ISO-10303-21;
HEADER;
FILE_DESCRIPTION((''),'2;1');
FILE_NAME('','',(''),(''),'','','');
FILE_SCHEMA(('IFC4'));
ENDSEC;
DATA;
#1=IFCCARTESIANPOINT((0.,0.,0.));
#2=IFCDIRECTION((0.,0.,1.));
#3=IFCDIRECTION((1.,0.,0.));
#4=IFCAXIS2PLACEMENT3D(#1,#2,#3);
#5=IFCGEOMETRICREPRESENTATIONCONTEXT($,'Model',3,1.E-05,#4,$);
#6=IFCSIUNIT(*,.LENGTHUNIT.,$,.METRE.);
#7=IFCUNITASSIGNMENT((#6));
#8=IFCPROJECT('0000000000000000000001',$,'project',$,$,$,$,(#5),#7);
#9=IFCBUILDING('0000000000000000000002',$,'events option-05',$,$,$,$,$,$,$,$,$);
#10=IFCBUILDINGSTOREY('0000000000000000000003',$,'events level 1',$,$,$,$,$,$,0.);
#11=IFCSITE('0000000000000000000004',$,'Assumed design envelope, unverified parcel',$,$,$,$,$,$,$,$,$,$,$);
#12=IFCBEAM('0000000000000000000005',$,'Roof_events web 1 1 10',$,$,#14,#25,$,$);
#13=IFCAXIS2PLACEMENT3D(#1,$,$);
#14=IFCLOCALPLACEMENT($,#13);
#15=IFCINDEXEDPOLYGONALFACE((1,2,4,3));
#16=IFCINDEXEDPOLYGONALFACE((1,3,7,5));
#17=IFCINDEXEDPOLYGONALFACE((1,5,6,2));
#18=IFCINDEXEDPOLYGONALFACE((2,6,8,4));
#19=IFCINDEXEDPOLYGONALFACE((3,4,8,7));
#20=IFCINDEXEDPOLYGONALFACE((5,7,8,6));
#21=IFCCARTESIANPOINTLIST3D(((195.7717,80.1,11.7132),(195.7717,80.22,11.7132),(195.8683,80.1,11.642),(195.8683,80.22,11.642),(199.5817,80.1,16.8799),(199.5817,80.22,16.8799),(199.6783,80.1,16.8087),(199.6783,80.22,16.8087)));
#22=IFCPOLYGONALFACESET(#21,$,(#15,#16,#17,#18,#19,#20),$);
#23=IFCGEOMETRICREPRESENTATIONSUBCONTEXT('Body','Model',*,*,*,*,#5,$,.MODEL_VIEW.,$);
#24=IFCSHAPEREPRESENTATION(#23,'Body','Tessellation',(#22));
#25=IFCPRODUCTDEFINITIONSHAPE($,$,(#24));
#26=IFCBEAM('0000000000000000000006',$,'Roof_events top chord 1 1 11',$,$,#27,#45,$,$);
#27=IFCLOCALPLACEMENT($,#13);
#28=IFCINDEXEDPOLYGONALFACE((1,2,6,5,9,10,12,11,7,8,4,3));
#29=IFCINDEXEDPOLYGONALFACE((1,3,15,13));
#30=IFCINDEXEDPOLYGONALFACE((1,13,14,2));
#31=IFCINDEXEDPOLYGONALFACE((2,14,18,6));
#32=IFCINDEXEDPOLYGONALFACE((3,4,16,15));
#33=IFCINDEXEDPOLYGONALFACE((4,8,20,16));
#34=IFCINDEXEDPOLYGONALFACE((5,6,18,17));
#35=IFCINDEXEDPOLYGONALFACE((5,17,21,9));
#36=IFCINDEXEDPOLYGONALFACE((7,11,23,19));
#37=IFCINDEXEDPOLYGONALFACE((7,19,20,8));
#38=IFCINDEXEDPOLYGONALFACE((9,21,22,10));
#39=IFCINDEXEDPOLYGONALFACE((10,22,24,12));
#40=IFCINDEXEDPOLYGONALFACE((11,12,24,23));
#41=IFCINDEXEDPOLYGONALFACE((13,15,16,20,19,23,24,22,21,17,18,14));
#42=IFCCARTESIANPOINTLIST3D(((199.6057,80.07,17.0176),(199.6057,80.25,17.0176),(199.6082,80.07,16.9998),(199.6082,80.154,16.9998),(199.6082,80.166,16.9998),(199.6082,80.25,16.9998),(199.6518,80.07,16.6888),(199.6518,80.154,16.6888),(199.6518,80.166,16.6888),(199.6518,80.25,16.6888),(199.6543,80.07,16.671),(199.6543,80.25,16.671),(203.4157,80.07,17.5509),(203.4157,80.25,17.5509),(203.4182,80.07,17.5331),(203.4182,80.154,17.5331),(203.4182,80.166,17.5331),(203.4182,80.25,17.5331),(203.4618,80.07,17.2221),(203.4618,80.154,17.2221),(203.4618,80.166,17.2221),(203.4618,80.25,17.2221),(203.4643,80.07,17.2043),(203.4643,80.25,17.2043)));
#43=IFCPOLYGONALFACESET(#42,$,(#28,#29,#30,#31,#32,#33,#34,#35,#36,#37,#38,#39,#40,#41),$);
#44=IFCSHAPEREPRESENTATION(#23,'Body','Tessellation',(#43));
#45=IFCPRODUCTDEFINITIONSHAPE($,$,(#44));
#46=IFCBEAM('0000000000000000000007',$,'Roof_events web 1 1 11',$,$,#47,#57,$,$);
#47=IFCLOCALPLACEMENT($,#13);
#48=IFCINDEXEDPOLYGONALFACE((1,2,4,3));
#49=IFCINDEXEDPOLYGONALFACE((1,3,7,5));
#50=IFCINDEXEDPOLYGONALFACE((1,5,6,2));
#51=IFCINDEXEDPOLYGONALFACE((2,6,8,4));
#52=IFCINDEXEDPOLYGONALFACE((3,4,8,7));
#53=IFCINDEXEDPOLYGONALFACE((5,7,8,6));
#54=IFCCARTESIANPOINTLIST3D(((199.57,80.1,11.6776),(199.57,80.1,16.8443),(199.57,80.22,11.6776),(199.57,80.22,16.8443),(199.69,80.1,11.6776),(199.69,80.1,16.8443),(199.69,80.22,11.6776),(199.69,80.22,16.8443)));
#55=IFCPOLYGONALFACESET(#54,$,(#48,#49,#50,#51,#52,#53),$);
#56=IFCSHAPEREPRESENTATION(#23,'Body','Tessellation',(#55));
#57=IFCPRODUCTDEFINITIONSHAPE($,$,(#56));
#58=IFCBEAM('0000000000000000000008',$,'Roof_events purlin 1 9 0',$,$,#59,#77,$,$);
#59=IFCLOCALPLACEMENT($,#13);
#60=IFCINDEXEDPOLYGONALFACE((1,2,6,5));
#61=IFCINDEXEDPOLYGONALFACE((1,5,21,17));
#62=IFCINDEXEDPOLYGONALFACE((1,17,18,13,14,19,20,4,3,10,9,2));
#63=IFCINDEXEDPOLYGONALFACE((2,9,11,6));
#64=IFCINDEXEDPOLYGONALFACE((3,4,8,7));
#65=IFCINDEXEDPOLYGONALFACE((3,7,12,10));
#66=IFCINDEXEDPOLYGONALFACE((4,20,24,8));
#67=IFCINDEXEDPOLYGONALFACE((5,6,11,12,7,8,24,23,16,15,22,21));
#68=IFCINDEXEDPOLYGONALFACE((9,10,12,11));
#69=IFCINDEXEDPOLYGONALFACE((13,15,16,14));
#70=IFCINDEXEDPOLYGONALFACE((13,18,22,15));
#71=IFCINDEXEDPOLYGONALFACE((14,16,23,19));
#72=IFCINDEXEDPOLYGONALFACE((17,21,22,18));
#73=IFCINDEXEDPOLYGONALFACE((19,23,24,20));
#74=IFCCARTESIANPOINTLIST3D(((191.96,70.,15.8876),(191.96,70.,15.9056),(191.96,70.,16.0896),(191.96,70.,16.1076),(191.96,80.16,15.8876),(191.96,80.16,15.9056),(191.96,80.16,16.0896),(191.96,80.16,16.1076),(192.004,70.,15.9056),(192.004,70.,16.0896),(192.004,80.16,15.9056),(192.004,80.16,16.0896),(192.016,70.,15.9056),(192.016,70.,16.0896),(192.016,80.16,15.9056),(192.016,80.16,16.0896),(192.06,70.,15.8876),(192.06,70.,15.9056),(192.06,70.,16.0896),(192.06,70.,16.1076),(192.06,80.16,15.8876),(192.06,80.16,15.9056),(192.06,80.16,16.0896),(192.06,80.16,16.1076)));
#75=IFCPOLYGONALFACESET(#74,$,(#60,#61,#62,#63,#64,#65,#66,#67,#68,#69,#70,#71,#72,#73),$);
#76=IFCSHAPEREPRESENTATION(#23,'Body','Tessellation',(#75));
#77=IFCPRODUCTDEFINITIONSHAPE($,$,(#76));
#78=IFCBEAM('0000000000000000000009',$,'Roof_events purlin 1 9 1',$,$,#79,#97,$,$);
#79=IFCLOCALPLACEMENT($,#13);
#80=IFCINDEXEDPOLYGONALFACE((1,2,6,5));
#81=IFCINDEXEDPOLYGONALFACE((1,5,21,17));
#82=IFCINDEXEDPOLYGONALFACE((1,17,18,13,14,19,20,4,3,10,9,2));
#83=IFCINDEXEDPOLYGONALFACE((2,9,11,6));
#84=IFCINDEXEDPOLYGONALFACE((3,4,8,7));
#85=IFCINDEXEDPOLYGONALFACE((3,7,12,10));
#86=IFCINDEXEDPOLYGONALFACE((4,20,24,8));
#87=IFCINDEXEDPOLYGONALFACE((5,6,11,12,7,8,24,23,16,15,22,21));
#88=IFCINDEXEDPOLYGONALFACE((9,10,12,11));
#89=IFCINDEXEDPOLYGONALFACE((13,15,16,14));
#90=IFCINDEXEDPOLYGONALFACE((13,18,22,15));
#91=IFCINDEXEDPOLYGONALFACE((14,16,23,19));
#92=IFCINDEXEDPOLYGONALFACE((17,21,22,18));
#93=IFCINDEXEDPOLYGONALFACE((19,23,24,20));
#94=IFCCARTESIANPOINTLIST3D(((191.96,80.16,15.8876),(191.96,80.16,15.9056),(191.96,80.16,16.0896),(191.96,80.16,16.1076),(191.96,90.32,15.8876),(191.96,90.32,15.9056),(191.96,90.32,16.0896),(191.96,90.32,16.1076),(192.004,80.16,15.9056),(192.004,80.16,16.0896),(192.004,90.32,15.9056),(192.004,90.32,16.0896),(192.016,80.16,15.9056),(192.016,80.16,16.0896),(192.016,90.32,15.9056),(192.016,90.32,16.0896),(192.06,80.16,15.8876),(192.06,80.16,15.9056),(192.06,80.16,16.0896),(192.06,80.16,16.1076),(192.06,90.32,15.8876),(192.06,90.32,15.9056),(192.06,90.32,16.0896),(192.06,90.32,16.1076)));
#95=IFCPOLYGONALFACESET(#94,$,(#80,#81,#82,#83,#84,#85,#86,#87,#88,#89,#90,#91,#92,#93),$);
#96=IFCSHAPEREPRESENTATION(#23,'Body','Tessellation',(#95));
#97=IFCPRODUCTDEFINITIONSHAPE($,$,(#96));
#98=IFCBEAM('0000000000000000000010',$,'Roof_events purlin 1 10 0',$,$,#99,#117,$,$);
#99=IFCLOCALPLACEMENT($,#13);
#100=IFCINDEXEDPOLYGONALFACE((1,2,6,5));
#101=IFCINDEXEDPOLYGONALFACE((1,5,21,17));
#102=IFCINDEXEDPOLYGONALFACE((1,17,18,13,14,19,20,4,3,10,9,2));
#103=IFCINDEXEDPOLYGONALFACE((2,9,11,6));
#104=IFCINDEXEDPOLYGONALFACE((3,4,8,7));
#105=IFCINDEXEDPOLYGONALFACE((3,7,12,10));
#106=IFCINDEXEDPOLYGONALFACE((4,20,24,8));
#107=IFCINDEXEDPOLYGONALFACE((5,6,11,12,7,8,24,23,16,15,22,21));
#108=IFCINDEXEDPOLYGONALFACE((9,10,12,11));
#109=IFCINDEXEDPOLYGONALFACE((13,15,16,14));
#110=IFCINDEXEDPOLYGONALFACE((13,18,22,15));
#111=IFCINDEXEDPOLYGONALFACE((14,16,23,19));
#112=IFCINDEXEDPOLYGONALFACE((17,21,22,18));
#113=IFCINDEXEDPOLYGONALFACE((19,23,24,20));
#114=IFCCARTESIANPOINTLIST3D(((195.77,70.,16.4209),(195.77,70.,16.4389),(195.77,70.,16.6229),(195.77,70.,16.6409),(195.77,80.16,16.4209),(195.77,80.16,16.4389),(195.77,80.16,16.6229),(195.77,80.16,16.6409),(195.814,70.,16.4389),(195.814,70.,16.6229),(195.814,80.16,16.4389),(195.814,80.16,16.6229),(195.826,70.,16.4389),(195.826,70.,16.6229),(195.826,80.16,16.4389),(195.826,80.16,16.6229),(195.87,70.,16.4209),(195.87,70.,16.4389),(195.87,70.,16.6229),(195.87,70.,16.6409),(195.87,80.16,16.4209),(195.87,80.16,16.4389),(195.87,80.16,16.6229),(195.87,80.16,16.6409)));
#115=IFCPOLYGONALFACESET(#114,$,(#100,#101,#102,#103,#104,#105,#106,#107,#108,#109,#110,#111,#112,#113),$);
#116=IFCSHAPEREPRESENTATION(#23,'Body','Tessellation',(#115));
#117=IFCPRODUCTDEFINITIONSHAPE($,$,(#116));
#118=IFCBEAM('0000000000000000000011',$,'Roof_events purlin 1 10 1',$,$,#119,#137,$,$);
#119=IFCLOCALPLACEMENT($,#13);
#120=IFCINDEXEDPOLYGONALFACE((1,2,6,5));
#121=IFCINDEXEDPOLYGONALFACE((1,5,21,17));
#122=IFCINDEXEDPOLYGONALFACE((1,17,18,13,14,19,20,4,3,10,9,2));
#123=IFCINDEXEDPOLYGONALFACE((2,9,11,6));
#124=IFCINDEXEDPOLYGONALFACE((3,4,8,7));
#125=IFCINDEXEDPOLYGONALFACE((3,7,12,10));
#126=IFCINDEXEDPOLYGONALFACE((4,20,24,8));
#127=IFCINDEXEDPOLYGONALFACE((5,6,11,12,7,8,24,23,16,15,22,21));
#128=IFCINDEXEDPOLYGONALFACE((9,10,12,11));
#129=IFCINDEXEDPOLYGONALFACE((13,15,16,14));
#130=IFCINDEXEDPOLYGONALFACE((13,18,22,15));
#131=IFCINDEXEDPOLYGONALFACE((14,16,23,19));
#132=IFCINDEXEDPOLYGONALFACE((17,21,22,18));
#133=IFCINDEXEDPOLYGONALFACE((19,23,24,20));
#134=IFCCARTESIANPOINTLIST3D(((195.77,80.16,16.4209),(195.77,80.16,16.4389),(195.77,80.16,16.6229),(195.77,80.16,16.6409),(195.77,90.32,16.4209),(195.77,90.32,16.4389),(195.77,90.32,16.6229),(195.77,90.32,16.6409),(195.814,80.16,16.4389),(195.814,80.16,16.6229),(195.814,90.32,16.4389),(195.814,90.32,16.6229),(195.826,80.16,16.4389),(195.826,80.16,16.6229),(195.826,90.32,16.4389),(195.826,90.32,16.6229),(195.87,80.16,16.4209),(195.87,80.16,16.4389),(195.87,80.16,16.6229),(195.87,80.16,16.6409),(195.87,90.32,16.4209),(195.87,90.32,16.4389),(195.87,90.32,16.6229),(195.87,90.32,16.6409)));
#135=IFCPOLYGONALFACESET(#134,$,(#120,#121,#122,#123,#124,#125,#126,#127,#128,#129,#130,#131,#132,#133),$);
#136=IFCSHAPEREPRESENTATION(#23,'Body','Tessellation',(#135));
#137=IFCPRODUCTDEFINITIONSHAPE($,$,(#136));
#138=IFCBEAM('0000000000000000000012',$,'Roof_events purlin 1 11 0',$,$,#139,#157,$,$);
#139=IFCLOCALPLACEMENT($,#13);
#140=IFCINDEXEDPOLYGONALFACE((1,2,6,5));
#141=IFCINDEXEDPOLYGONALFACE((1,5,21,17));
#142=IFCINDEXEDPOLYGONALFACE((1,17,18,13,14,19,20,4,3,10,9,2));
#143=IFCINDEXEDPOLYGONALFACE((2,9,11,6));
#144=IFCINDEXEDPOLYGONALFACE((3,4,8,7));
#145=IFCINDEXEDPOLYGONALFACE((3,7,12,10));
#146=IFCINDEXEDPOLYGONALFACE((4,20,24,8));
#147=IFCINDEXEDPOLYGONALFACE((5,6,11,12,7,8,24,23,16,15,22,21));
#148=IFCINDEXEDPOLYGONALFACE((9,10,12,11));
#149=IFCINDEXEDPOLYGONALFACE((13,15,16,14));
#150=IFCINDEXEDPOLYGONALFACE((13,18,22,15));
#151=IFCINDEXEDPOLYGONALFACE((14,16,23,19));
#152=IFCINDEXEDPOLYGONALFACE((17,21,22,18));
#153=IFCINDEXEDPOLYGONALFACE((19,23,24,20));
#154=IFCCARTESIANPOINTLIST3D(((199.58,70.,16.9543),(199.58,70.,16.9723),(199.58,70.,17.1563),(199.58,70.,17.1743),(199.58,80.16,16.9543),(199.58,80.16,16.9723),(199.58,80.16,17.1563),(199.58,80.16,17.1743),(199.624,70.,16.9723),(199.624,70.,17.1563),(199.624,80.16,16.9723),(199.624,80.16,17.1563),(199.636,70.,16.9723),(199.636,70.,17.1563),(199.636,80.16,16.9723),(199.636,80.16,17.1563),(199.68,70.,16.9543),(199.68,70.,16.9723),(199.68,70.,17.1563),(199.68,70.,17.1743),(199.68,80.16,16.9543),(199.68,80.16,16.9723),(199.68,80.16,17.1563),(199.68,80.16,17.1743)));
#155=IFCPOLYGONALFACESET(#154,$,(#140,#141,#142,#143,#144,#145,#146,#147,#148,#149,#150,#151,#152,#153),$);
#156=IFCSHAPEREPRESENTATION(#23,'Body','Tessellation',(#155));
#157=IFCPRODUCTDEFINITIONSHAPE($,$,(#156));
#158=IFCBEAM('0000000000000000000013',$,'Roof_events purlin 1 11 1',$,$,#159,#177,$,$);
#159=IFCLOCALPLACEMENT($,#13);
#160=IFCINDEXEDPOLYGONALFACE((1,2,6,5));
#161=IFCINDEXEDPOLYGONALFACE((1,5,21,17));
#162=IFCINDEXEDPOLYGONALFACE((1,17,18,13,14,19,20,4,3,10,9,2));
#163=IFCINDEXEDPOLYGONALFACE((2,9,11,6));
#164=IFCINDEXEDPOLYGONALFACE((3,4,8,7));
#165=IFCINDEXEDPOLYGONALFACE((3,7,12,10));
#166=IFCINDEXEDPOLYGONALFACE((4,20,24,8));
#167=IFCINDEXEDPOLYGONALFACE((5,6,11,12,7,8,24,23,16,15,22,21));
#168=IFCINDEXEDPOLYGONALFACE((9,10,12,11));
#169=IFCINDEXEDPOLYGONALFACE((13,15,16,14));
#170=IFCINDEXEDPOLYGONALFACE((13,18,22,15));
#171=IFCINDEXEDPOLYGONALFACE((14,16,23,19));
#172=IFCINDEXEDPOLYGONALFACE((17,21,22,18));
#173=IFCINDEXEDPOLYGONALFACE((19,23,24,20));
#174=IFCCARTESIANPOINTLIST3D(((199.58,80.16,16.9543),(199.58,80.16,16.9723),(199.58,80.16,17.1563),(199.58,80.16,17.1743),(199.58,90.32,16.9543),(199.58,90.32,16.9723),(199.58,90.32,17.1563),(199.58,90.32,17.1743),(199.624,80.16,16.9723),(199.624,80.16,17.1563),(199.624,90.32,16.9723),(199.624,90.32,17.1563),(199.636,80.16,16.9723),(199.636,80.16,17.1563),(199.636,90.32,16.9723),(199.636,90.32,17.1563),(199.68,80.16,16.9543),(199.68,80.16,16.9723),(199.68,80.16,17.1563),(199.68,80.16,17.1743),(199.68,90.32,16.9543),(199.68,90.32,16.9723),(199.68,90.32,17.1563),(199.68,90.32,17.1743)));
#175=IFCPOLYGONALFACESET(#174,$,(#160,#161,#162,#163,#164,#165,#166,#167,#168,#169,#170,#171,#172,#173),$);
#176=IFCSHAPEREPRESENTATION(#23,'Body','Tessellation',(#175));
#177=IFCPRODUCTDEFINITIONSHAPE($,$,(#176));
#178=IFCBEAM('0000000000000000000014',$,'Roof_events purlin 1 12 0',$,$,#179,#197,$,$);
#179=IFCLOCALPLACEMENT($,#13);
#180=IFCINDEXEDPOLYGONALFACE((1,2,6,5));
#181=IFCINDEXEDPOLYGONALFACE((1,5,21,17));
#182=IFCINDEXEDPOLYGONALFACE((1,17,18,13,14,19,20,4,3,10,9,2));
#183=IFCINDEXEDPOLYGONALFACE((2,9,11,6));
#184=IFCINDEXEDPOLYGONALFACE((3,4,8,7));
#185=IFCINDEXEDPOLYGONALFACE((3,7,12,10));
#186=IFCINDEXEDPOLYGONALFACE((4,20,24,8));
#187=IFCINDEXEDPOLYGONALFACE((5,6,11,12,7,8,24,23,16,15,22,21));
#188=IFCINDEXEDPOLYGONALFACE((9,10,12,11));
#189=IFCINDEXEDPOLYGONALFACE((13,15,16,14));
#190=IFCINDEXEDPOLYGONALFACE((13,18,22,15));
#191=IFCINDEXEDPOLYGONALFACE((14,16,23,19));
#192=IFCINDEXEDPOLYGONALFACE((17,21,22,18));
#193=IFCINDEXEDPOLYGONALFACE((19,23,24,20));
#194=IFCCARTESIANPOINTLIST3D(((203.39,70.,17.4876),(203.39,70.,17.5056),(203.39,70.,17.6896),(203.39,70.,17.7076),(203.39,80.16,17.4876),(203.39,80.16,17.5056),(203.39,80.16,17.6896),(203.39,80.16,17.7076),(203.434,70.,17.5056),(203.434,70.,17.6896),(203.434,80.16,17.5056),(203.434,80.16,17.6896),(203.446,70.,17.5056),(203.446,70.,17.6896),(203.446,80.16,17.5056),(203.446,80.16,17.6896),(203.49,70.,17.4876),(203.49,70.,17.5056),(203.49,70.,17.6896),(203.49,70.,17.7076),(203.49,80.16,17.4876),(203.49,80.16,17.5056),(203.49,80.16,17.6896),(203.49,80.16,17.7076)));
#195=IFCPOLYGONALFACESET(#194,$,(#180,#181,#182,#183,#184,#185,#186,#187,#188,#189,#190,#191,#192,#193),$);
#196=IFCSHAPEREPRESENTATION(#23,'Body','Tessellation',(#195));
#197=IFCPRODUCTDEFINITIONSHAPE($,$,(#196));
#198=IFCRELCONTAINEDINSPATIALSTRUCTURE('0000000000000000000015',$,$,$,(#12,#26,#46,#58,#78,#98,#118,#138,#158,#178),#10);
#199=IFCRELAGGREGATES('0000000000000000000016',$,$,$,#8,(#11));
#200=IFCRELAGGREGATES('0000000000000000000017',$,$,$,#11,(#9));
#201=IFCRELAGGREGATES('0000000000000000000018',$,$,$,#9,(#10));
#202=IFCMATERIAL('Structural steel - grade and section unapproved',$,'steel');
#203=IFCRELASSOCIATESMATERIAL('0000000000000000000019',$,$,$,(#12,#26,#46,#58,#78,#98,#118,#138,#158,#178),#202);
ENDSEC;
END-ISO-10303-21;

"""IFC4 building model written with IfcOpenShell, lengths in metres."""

from ifc_helpers import new_model, si_unit, frame, origin_with_axes, place, context, subcontext, project, spatial, rectangle, i_section, extrude, material, element, save


model = new_model("IFC4")

# Units and contexts
model_context = context("Model", 3, precision=1e-05, world=origin_with_axes())
body_context = subcontext(model_context, "Body", "Model", "MODEL_VIEW")
ifc_project = project(units=[si_unit("LENGTHUNIT", "METRE")], contexts=[model_context])

# Site, building, storey
site = spatial("IfcSite", under=ifc_project, Name="Assumed design envelope, unverified parcel")
building = spatial("IfcBuilding", under=site, Name="events option-05")
storey = spatial("IfcBuildingStorey", under=building, Name="events level 1", Elevation=0.0)

# Shared definitions
ifc_material_1 = material(Name="Structural steel - grade and section unapproved", Category="steel")

# Beams
beam_1_placement = place(None, frame((195.82, 80.16, 11.6776), z_axis=(0.5935, 0.0, 0.804834), x_axis=(0.0, 1.0, 0.0)))
element("IfcBeam", 1, at=beam_1_placement, inside=storey, material=ifc_material_1, Name="Roof_events web 1 1 10", context=body_context, shape_type="SweptSolid", body=[
    extrude(rectangle(XDim=0.12, YDim=0.12), origin_with_axes(), (0.0, 0.0, 1.0), 6.4195),
])
beam_2_placement = place(None, frame((199.63, 80.16, 16.8443), z_axis=(0.990344, 0.0, 0.138631), x_axis=(0.0, 1.0, 0.0)))
element("IfcBeam", 2, at=beam_2_placement, inside=storey, material=ifc_material_1, Name="Roof_events top chord 1 1 11", context=body_context, shape_type="SweptSolid", body=[
    extrude(i_section(OverallWidth=0.18, OverallDepth=0.35, WebThickness=0.012, FlangeThickness=0.018, FilletRadius=0.0), origin_with_axes(), (0.0, 0.0, 1.0), 3.8471),
])
beam_3_placement = place(None, frame((199.63, 80.16, 11.6776), z_axis=(0.0, 0.0, 1.0), x_axis=(-1.0, 0.0, 0.0)))
element("IfcBeam", 3, at=beam_3_placement, inside=storey, material=ifc_material_1, Name="Roof_events web 1 1 11", context=body_context, shape_type="SweptSolid", body=[
    extrude(rectangle(XDim=0.12, YDim=0.12), origin_with_axes(), (0.0, 0.0, 1.0), 5.1667),
])
beam_4_placement = place(None, frame((192.01, 70.0, 15.9976), z_axis=(0.0, 1.0, 0.0), x_axis=(-1.0, 0.0, 0.0)))
element("IfcBeam", 4, at=beam_4_placement, inside=storey, material=ifc_material_1, Name="Roof_events purlin 1 9 0", context=body_context, shape_type="SweptSolid", body=[
    extrude(i_section(OverallWidth=0.1, OverallDepth=0.22, WebThickness=0.012, FlangeThickness=0.018, FilletRadius=0.0), origin_with_axes(), (0.0, 0.0, 1.0), 10.16),
])
beam_5_placement = place(None, frame((192.01, 80.16, 15.9976), z_axis=(0.0, 1.0, 0.0), x_axis=(-1.0, 0.0, 0.0)))
element("IfcBeam", 5, at=beam_5_placement, inside=storey, material=ifc_material_1, Name="Roof_events purlin 1 9 1", context=body_context, shape_type="SweptSolid", body=[
    extrude(i_section(OverallWidth=0.1, OverallDepth=0.22, WebThickness=0.012, FlangeThickness=0.018, FilletRadius=0.0), origin_with_axes(), (0.0, 0.0, 1.0), 10.16),
])
beam_6_placement = place(None, frame((195.82, 70.0, 16.5309), z_axis=(0.0, 1.0, 0.0), x_axis=(-1.0, 0.0, 0.0)))
element("IfcBeam", 6, at=beam_6_placement, inside=storey, material=ifc_material_1, Name="Roof_events purlin 1 10 0", context=body_context, shape_type="SweptSolid", body=[
    extrude(i_section(OverallWidth=0.1, OverallDepth=0.22, WebThickness=0.012, FlangeThickness=0.018, FilletRadius=0.0), origin_with_axes(), (0.0, 0.0, 1.0), 10.16),
])
beam_7_placement = place(None, frame((195.82, 80.16, 16.5309), z_axis=(0.0, 1.0, 0.0), x_axis=(-1.0, 0.0, 0.0)))
element("IfcBeam", 7, at=beam_7_placement, inside=storey, material=ifc_material_1, Name="Roof_events purlin 1 10 1", context=body_context, shape_type="SweptSolid", body=[
    extrude(i_section(OverallWidth=0.1, OverallDepth=0.22, WebThickness=0.012, FlangeThickness=0.018, FilletRadius=0.0), origin_with_axes(), (0.0, 0.0, 1.0), 10.16),
])
beam_8_placement = place(None, frame((199.63, 70.0, 17.0643), z_axis=(0.0, 1.0, 0.0), x_axis=(-1.0, 0.0, 0.0)))
element("IfcBeam", 8, at=beam_8_placement, inside=storey, material=ifc_material_1, Name="Roof_events purlin 1 11 0", context=body_context, shape_type="SweptSolid", body=[
    extrude(i_section(OverallWidth=0.1, OverallDepth=0.22, WebThickness=0.012, FlangeThickness=0.018, FilletRadius=0.0), origin_with_axes(), (0.0, 0.0, 1.0), 10.16),
])
beam_9_placement = place(None, frame((199.63, 80.16, 17.0643), z_axis=(0.0, 1.0, 0.0), x_axis=(-1.0, 0.0, 0.0)))
element("IfcBeam", 9, at=beam_9_placement, inside=storey, material=ifc_material_1, Name="Roof_events purlin 1 11 1", context=body_context, shape_type="SweptSolid", body=[
    extrude(i_section(OverallWidth=0.1, OverallDepth=0.22, WebThickness=0.012, FlangeThickness=0.018, FilletRadius=0.0), origin_with_axes(), (0.0, 0.0, 1.0), 10.16),
])
beam_10_placement = place(None, frame((203.44, 70.0, 17.5976), z_axis=(0.0, 1.0, 0.0), x_axis=(-1.0, 0.0, 0.0)))
element("IfcBeam", 10, at=beam_10_placement, inside=storey, material=ifc_material_1, Name="Roof_events purlin 1 12 0", context=body_context, shape_type="SweptSolid", body=[
    extrude(i_section(OverallWidth=0.1, OverallDepth=0.22, WebThickness=0.012, FlangeThickness=0.018, FilletRadius=0.0), origin_with_axes(), (0.0, 0.0, 1.0), 10.16),
])

save(model, "model.ifc")
